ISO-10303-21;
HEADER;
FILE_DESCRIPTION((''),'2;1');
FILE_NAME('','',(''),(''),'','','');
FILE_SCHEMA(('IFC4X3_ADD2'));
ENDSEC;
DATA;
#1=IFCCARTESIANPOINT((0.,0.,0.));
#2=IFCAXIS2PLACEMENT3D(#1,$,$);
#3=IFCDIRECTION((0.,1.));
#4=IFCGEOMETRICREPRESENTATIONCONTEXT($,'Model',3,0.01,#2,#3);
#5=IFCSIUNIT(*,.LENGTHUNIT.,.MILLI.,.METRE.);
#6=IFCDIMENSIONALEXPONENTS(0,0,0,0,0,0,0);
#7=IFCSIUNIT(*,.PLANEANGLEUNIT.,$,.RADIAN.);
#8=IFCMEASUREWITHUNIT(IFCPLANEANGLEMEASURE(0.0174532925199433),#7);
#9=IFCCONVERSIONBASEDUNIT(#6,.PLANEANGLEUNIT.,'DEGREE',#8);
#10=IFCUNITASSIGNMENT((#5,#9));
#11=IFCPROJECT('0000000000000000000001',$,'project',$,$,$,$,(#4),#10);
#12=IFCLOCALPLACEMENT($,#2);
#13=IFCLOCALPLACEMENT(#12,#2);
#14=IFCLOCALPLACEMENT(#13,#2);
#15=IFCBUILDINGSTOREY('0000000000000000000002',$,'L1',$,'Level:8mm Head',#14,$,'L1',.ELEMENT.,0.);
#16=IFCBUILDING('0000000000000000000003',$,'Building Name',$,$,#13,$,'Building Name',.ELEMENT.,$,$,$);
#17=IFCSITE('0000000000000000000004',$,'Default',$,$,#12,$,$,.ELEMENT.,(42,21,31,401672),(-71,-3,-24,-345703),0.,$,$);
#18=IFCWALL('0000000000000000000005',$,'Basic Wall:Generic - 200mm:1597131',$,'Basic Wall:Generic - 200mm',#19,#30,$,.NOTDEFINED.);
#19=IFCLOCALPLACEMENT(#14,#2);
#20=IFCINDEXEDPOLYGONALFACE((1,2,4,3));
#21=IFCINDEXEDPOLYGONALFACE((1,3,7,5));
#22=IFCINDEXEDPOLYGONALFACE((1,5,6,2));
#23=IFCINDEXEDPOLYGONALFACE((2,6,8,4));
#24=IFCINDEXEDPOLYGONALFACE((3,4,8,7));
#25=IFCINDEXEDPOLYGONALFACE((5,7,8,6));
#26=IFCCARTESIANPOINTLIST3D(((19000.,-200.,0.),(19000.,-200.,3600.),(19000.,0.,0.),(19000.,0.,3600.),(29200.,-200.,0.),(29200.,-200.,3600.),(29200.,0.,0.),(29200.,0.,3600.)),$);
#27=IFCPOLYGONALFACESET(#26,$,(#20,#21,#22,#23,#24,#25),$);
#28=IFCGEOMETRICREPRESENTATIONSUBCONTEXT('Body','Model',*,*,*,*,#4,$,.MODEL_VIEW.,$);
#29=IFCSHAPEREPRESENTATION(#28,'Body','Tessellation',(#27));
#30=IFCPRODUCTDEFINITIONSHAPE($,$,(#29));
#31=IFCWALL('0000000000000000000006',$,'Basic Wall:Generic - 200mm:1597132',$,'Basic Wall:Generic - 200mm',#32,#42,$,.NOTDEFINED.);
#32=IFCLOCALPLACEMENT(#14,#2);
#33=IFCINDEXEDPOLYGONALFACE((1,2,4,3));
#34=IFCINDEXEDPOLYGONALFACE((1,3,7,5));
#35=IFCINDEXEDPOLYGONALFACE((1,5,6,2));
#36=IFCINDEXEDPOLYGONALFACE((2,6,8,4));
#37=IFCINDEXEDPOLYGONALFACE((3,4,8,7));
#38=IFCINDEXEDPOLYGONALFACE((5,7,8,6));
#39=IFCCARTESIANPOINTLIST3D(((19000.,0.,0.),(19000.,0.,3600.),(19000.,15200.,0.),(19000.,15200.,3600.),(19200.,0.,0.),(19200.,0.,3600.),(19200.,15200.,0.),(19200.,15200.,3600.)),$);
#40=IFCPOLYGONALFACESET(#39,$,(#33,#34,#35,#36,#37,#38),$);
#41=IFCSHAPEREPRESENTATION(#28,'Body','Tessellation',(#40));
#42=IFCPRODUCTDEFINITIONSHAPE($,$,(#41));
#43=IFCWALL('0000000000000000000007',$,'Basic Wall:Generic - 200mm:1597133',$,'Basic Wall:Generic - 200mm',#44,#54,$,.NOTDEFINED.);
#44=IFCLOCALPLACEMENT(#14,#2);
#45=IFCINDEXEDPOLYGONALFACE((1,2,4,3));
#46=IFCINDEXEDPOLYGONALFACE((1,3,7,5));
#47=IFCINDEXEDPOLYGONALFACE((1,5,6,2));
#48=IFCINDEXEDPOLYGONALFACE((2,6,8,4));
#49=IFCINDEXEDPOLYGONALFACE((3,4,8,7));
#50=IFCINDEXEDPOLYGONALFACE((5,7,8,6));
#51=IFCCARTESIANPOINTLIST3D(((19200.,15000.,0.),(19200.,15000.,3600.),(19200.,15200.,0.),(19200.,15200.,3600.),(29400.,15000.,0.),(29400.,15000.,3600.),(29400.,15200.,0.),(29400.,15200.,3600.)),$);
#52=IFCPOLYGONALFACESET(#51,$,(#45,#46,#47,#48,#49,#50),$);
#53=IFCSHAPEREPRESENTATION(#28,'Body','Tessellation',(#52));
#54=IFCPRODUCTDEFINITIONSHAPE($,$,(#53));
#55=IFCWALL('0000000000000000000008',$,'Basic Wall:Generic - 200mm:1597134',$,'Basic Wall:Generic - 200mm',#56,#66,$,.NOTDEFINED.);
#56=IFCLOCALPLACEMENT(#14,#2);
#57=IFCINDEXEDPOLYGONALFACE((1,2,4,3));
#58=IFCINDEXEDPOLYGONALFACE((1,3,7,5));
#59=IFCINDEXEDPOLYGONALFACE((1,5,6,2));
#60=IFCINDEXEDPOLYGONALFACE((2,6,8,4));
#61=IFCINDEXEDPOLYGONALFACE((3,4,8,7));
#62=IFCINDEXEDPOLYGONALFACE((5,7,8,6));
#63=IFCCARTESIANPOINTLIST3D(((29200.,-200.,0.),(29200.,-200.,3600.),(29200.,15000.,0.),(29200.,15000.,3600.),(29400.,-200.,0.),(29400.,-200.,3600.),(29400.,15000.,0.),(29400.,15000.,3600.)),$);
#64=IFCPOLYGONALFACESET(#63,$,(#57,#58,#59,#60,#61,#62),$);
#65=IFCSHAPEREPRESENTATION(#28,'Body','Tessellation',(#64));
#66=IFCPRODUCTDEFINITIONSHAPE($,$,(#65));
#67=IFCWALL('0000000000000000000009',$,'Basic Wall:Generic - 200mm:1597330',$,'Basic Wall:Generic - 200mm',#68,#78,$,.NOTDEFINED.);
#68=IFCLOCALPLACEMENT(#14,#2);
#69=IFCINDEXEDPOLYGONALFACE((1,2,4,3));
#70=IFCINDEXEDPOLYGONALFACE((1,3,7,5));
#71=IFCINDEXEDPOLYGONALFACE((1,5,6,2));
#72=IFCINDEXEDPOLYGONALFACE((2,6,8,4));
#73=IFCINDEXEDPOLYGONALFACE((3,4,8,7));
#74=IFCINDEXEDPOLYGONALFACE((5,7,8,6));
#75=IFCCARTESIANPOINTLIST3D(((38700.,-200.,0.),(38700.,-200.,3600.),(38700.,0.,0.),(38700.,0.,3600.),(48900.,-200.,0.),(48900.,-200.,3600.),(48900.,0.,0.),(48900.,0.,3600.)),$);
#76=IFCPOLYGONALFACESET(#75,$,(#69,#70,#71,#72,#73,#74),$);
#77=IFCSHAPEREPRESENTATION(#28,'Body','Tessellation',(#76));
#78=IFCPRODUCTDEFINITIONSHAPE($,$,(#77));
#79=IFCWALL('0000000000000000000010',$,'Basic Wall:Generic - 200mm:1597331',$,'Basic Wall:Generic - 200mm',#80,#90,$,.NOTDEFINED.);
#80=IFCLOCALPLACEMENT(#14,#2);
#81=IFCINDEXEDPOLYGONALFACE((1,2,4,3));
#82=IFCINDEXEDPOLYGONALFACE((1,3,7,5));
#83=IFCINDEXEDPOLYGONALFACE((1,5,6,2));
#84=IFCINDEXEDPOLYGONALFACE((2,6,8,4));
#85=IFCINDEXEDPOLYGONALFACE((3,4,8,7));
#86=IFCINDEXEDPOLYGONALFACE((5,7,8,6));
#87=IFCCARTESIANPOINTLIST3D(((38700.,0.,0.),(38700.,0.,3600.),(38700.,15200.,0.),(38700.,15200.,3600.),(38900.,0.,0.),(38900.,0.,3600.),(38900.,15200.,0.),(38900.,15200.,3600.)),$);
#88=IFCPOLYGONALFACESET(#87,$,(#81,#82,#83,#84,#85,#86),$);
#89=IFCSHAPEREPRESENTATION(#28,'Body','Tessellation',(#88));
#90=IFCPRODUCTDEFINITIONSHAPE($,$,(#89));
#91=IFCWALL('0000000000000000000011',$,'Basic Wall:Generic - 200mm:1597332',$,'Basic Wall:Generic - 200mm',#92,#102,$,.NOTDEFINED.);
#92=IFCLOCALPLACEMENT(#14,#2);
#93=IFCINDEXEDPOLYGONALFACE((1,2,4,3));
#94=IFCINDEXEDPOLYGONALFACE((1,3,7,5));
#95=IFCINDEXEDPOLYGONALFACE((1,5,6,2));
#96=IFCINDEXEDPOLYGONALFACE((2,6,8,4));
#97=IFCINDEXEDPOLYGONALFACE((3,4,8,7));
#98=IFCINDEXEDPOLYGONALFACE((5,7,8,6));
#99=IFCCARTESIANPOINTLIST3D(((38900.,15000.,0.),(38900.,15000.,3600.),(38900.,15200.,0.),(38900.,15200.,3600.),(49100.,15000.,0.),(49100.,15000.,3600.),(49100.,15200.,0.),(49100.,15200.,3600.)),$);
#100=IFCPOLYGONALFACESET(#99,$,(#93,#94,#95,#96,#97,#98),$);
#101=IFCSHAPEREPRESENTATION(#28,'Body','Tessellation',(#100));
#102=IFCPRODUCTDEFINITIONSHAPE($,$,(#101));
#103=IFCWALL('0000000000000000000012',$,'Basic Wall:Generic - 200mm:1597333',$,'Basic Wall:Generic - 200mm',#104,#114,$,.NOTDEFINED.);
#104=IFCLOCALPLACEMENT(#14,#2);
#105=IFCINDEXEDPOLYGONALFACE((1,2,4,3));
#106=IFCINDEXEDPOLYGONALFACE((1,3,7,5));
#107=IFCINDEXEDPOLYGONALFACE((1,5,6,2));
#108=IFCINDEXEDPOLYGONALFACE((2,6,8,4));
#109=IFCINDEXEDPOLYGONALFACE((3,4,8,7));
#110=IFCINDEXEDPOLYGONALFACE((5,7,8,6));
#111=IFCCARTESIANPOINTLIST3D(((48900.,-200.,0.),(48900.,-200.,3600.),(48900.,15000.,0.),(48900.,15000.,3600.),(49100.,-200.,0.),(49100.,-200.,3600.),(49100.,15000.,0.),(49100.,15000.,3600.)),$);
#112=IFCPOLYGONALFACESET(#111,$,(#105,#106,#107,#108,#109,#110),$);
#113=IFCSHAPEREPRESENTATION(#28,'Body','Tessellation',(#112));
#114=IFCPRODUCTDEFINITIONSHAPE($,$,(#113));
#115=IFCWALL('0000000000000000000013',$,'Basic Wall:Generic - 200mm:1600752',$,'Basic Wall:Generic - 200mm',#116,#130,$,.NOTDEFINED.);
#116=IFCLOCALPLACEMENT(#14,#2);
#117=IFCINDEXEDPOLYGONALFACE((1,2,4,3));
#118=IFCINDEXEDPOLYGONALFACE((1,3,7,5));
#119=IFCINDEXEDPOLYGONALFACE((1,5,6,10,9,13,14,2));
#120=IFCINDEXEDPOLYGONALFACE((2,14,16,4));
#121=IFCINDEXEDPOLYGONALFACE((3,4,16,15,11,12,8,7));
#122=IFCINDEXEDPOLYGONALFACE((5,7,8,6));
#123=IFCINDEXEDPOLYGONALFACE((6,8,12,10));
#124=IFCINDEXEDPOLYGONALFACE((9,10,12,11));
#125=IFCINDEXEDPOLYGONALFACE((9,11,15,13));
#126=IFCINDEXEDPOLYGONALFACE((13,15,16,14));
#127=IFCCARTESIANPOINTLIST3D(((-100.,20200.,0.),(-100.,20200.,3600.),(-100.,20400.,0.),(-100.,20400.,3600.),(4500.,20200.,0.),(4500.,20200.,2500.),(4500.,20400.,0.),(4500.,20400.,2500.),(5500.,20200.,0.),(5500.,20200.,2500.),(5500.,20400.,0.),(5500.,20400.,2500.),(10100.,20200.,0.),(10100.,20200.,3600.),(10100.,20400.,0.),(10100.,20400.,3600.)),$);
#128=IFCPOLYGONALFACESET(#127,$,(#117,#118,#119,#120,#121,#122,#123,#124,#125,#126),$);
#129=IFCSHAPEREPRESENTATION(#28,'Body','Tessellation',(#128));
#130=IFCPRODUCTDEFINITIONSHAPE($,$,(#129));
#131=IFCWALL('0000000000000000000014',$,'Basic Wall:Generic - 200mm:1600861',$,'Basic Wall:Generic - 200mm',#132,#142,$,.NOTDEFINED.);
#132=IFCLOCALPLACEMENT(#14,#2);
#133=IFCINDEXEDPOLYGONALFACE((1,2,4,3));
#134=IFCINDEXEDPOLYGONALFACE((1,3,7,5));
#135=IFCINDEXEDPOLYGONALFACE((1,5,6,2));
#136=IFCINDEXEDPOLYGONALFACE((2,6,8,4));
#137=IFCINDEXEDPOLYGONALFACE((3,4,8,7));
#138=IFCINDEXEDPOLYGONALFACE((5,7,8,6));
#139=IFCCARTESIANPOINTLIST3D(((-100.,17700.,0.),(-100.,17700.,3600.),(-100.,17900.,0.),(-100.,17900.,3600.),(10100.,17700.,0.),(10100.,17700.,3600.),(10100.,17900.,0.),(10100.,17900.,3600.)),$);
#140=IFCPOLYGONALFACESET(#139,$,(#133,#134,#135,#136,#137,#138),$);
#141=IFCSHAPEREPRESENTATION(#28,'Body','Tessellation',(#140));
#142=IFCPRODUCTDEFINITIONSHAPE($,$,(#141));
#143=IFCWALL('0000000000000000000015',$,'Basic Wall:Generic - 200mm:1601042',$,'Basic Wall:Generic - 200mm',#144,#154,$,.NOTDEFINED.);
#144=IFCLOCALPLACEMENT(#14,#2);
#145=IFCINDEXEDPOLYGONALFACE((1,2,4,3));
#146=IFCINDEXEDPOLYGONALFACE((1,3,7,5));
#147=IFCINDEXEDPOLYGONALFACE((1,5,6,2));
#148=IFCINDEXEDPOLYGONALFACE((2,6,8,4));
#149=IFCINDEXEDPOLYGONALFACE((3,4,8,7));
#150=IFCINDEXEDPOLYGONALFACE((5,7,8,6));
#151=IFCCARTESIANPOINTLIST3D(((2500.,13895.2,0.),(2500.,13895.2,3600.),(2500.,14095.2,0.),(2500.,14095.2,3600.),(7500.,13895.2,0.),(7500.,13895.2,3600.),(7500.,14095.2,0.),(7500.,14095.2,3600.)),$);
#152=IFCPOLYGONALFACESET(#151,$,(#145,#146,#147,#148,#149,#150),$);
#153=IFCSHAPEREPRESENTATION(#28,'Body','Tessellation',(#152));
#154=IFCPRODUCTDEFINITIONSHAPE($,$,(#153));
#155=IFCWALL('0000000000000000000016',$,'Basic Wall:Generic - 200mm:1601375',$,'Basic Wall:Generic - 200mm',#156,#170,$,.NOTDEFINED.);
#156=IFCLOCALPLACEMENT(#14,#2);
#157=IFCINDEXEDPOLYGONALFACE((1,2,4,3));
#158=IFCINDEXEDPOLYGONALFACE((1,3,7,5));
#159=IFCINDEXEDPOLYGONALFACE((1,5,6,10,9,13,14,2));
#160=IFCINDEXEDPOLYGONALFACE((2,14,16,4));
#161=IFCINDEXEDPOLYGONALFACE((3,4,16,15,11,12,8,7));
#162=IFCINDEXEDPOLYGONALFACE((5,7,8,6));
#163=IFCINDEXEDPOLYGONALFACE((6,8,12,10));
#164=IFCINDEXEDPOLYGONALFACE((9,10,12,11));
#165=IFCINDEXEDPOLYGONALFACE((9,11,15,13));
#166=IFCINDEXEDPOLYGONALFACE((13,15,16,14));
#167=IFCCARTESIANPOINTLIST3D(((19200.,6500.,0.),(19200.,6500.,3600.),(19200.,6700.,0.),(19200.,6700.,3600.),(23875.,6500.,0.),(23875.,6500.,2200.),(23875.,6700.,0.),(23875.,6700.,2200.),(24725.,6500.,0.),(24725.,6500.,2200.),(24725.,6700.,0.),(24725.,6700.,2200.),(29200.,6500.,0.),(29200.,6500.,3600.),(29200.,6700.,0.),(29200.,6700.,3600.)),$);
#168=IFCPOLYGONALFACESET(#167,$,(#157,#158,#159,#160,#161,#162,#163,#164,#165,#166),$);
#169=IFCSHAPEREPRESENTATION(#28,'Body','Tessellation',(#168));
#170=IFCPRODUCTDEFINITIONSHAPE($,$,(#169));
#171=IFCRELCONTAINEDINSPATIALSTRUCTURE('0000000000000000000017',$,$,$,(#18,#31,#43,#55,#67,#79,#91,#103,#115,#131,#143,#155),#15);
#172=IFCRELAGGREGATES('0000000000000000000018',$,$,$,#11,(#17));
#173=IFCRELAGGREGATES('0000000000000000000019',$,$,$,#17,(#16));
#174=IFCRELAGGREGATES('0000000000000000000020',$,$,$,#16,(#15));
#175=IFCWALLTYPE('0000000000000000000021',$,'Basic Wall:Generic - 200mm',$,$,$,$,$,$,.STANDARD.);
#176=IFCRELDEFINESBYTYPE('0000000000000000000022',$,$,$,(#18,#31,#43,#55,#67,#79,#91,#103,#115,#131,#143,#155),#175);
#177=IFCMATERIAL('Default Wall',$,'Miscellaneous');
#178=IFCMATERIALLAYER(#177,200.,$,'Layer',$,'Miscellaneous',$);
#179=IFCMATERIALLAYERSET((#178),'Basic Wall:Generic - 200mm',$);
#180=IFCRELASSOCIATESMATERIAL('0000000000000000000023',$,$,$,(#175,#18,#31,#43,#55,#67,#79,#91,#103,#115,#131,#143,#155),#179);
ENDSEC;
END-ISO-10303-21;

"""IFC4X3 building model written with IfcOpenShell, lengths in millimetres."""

from ifc_helpers import new_model, entity, si_unit, converted_unit, direction, frame, frame_2d, origin, origin_2d_with_axis, place, context, subcontext, project, spatial, rectangle, extrude, material, layer, layer_set, type_object, element, save


model = new_model("IFC4X3")

# Units and contexts
model_context = context("Model", 3, precision=0.01, world=origin(), true_north=direction((0.0, 1.0)))
body_context = subcontext(model_context, "Body", "Model", "MODEL_VIEW")
ifc_project = project(units=[si_unit("LENGTHUNIT", "METRE", prefix="MILLI"), converted_unit("PLANEANGLEUNIT", "DEGREE", entity("IfcPlaneAngleMeasure", 0.0174532925199433), si_unit("PLANEANGLEUNIT", "RADIAN"), dimensions=[0, 0, 0, 0, 0, 0, 0])], contexts=[model_context])

# Site, building, storey
site_placement = place(None, origin())
site = spatial("IfcSite", under=ifc_project, at=site_placement, Name="Default", CompositionType="ELEMENT", RefLatitude=(42, 21, 31, 401672), RefLongitude=(-71, -3, -24, -345703), RefElevation=0.0)
building_placement = place(site_placement, origin())
building = spatial("IfcBuilding", under=site, at=building_placement, Name="Building Name", LongName="Building Name", CompositionType="ELEMENT")
storey_placement = place(building_placement, origin())
storey = spatial("IfcBuildingStorey", under=building, at=storey_placement, Name="L1", ObjectType="Level:8mm Head", LongName="L1", CompositionType="ELEMENT", Elevation=0.0)

# Walls
ifc_material_1 = material(Name="Default Wall", Category="Miscellaneous")
ifc_layer_1 = layer(ifc_material_1, 200.0, Name="Layer", Category="Miscellaneous")
ifc_layer_set_1 = layer_set([ifc_layer_1], Name="Basic Wall:Generic - 200mm")
wall_type_1 = type_object("IfcWallType", Name="Basic Wall:Generic - 200mm", PredefinedType="STANDARD", material=ifc_layer_set_1)
wall_1_placement = place(storey_placement, frame((19000.0, -100.0, 0.0)))
element("IfcWall", 1, at=wall_1_placement, inside=storey, type_object=wall_type_1, material=ifc_layer_set_1, Name="Basic Wall:Generic - 200mm:1597131", ObjectType="Basic Wall:Generic - 200mm", PredefinedType="NOTDEFINED", context=body_context, shape_type="SweptSolid", body=[
    extrude(rectangle(XDim=10200.0, YDim=200.0, at=frame_2d((5100.0, 0.0), x_axis=(-1.0, 0.0))), origin(), (0.0, 0.0, 1.0), 3600.0),
])
wall_2_placement = place(storey_placement, frame((19100.0, 15200.0, 0.0), z_axis=(0.0, 0.0, 1.0), x_axis=(0.0, -1.0, 0.0)))
element("IfcWall", 2, at=wall_2_placement, inside=storey, type_object=wall_type_1, material=ifc_layer_set_1, Name="Basic Wall:Generic - 200mm:1597132", ObjectType="Basic Wall:Generic - 200mm", PredefinedType="NOTDEFINED", context=body_context, shape_type="SweptSolid", body=[
    extrude(rectangle(XDim=15200.0, YDim=200.0, at=frame_2d((7600.0, 0.0), x_axis=(-1.0, 0.0))), origin(), (0.0, 0.0, 1.0), 3600.0),
])
wall_3_placement = place(storey_placement, frame((29400.0, 15100.0, 0.0), z_axis=(0.0, 0.0, 1.0), x_axis=(-1.0, 0.0, 0.0)))
element("IfcWall", 3, at=wall_3_placement, inside=storey, type_object=wall_type_1, material=ifc_layer_set_1, Name="Basic Wall:Generic - 200mm:1597133", ObjectType="Basic Wall:Generic - 200mm", PredefinedType="NOTDEFINED", context=body_context, shape_type="SweptSolid", body=[
    extrude(rectangle(XDim=10200.0, YDim=200.0, at=frame_2d((5100.0, 0.0), x_axis=(-1.0, 0.0))), origin(), (0.0, 0.0, 1.0), 3600.0),
])
wall_4_placement = place(storey_placement, frame((29300.0, -200.0, 0.0), z_axis=(0.0, 0.0, 1.0), x_axis=(0.0, 1.0, 0.0)))
element("IfcWall", 4, at=wall_4_placement, inside=storey, type_object=wall_type_1, material=ifc_layer_set_1, Name="Basic Wall:Generic - 200mm:1597134", ObjectType="Basic Wall:Generic - 200mm", PredefinedType="NOTDEFINED", context=body_context, shape_type="SweptSolid", body=[
    extrude(rectangle(XDim=15200.0, YDim=200.0, at=frame_2d((7600.0, 0.0), x_axis=(-1.0, 0.0))), origin(), (0.0, 0.0, 1.0), 3600.0),
])
wall_5_placement = place(storey_placement, frame((38700.0, -100.0, 0.0)))
element("IfcWall", 5, at=wall_5_placement, inside=storey, type_object=wall_type_1, material=ifc_layer_set_1, Name="Basic Wall:Generic - 200mm:1597330", ObjectType="Basic Wall:Generic - 200mm", PredefinedType="NOTDEFINED", context=body_context, shape_type="SweptSolid", body=[
    extrude(rectangle(XDim=10200.0, YDim=200.0, at=frame_2d((5100.0, 0.0), x_axis=(-1.0, 0.0))), origin(), (0.0, 0.0, 1.0), 3600.0),
])
wall_6_placement = place(storey_placement, frame((38800.0, 15200.0, 0.0), z_axis=(0.0, 0.0, 1.0), x_axis=(0.0, -1.0, 0.0)))
element("IfcWall", 6, at=wall_6_placement, inside=storey, type_object=wall_type_1, material=ifc_layer_set_1, Name="Basic Wall:Generic - 200mm:1597331", ObjectType="Basic Wall:Generic - 200mm", PredefinedType="NOTDEFINED", context=body_context, shape_type="SweptSolid", body=[
    extrude(rectangle(XDim=15200.0, YDim=200.0, at=frame_2d((7600.0, 0.0), x_axis=(-1.0, 0.0))), origin(), (0.0, 0.0, 1.0), 3600.0),
])
wall_7_placement = place(storey_placement, frame((49100.0, 15100.0, 0.0), z_axis=(0.0, 0.0, 1.0), x_axis=(-1.0, 0.0, 0.0)))
element("IfcWall", 7, at=wall_7_placement, inside=storey, type_object=wall_type_1, material=ifc_layer_set_1, Name="Basic Wall:Generic - 200mm:1597332", ObjectType="Basic Wall:Generic - 200mm", PredefinedType="NOTDEFINED", context=body_context, shape_type="SweptSolid", body=[
    extrude(rectangle(XDim=10200.0, YDim=200.0, at=frame_2d((5100.0, 0.0), x_axis=(-1.0, 0.0))), origin(), (0.0, 0.0, 1.0), 3600.0),
])
wall_8_placement = place(storey_placement, frame((49000.0, -200.0, 0.0), z_axis=(0.0, 0.0, 1.0), x_axis=(0.0, 1.0, 0.0)))
element("IfcWall", 8, at=wall_8_placement, inside=storey, type_object=wall_type_1, material=ifc_layer_set_1, Name="Basic Wall:Generic - 200mm:1597333", ObjectType="Basic Wall:Generic - 200mm", PredefinedType="NOTDEFINED", context=body_context, shape_type="SweptSolid", body=[
    extrude(rectangle(XDim=15200.0, YDim=200.0, at=frame_2d((7600.0, 0.0), x_axis=(-1.0, 0.0))), origin(), (0.0, 0.0, 1.0), 3600.0),
])

# Wall, opening
wall_9_placement = place(storey_placement, frame((10100.0, 20300.0, 0.0), z_axis=(0.0, 0.0, 1.0), x_axis=(-1.0, 0.0, 0.0)))
wall_9 = element("IfcWall", 9, at=wall_9_placement, inside=storey, type_object=wall_type_1, material=ifc_layer_set_1, Name="Basic Wall:Generic - 200mm:1600752", ObjectType="Basic Wall:Generic - 200mm", PredefinedType="NOTDEFINED", context=body_context, shape_type="SweptSolid", body=[
    extrude(rectangle(XDim=10200.0, YDim=200.0, at=frame_2d((5100.0, 0.0), x_axis=(1.0, 0.0))), origin(), (0.0, 0.0, 1.0), 3600.0),
])
opening_1_placement = place(wall_9_placement, frame((5600.0, 100.0, 0.0)))
element("IfcOpeningElement", 10, at=opening_1_placement, cuts=wall_9, PredefinedType="OPENING", context=body_context, shape_type="SweptSolid", body=[
    extrude(rectangle(XDim=2500.0, YDim=1000.0, at=origin_2d_with_axis()), frame((-500.0, -200.0, 1250.0), z_axis=(0.0, 1.0, 0.0), x_axis=(0.0, 0.0, -1.0)), (0.0, 0.0, 1.0), 200.0),
])

# Walls
wall_10_placement = place(storey_placement, frame((10100.0, 17800.0, 0.0), z_axis=(0.0, 0.0, 1.0), x_axis=(-1.0, 0.0, 0.0)))
element("IfcWall", 11, at=wall_10_placement, inside=storey, type_object=wall_type_1, material=ifc_layer_set_1, Name="Basic Wall:Generic - 200mm:1600861", ObjectType="Basic Wall:Generic - 200mm", PredefinedType="NOTDEFINED", context=body_context, shape_type="SweptSolid", body=[
    extrude(rectangle(XDim=10200.0, YDim=200.0, at=frame_2d((5100.0, 0.0), x_axis=(-1.0, 0.0))), origin(), (0.0, 0.0, 1.0), 3600.0),
])
wall_11_placement = place(storey_placement, frame((7500.0, 13995.2, 0.0), z_axis=(0.0, 0.0, 1.0), x_axis=(-1.0, 0.0, 0.0)))
element("IfcWall", 12, at=wall_11_placement, inside=storey, type_object=wall_type_1, material=ifc_layer_set_1, Name="Basic Wall:Generic - 200mm:1601042", ObjectType="Basic Wall:Generic - 200mm", PredefinedType="NOTDEFINED", context=body_context, shape_type="SweptSolid", body=[
    extrude(rectangle(XDim=5000.0, YDim=200.0, at=frame_2d((2500.0, 0.0), x_axis=(-1.0, 0.0))), origin(), (0.0, 0.0, 1.0), 3600.0),
])

# Wall, opening
wall_12_placement = place(storey_placement, frame((29200.0, 6600.0, 0.0), z_axis=(0.0, 0.0, 1.0), x_axis=(-1.0, 0.0, 0.0)))
wall_12 = element("IfcWall", 13, at=wall_12_placement, inside=storey, type_object=wall_type_1, material=ifc_layer_set_1, Name="Basic Wall:Generic - 200mm:1601375", ObjectType="Basic Wall:Generic - 200mm", PredefinedType="NOTDEFINED", context=body_context, shape_type="SweptSolid", body=[
    extrude(rectangle(XDim=10000.0, YDim=200.0, at=frame_2d((5000.0, 0.0), x_axis=(1.0, 0.0))), origin(), (0.0, 0.0, 1.0), 3600.0),
])
opening_2_placement = place(wall_12_placement, frame((5325.0, 100.0, 0.0)))
element("IfcOpeningElement", 14, at=opening_2_placement, cuts=wall_12, PredefinedType="OPENING", context=body_context, shape_type="SweptSolid", body=[
    extrude(rectangle(XDim=2200.0, YDim=850.0, at=frame_2d((1100.0, 425.0), x_axis=(1.0, 0.0))), frame((0.0, 0.0, 0.0), z_axis=(0.0, -1.0, 0.0), x_axis=(0.0, 0.0, 1.0)), (0.0, 0.0, 1.0), 200.0),
])

save(model, "model.ifc")
